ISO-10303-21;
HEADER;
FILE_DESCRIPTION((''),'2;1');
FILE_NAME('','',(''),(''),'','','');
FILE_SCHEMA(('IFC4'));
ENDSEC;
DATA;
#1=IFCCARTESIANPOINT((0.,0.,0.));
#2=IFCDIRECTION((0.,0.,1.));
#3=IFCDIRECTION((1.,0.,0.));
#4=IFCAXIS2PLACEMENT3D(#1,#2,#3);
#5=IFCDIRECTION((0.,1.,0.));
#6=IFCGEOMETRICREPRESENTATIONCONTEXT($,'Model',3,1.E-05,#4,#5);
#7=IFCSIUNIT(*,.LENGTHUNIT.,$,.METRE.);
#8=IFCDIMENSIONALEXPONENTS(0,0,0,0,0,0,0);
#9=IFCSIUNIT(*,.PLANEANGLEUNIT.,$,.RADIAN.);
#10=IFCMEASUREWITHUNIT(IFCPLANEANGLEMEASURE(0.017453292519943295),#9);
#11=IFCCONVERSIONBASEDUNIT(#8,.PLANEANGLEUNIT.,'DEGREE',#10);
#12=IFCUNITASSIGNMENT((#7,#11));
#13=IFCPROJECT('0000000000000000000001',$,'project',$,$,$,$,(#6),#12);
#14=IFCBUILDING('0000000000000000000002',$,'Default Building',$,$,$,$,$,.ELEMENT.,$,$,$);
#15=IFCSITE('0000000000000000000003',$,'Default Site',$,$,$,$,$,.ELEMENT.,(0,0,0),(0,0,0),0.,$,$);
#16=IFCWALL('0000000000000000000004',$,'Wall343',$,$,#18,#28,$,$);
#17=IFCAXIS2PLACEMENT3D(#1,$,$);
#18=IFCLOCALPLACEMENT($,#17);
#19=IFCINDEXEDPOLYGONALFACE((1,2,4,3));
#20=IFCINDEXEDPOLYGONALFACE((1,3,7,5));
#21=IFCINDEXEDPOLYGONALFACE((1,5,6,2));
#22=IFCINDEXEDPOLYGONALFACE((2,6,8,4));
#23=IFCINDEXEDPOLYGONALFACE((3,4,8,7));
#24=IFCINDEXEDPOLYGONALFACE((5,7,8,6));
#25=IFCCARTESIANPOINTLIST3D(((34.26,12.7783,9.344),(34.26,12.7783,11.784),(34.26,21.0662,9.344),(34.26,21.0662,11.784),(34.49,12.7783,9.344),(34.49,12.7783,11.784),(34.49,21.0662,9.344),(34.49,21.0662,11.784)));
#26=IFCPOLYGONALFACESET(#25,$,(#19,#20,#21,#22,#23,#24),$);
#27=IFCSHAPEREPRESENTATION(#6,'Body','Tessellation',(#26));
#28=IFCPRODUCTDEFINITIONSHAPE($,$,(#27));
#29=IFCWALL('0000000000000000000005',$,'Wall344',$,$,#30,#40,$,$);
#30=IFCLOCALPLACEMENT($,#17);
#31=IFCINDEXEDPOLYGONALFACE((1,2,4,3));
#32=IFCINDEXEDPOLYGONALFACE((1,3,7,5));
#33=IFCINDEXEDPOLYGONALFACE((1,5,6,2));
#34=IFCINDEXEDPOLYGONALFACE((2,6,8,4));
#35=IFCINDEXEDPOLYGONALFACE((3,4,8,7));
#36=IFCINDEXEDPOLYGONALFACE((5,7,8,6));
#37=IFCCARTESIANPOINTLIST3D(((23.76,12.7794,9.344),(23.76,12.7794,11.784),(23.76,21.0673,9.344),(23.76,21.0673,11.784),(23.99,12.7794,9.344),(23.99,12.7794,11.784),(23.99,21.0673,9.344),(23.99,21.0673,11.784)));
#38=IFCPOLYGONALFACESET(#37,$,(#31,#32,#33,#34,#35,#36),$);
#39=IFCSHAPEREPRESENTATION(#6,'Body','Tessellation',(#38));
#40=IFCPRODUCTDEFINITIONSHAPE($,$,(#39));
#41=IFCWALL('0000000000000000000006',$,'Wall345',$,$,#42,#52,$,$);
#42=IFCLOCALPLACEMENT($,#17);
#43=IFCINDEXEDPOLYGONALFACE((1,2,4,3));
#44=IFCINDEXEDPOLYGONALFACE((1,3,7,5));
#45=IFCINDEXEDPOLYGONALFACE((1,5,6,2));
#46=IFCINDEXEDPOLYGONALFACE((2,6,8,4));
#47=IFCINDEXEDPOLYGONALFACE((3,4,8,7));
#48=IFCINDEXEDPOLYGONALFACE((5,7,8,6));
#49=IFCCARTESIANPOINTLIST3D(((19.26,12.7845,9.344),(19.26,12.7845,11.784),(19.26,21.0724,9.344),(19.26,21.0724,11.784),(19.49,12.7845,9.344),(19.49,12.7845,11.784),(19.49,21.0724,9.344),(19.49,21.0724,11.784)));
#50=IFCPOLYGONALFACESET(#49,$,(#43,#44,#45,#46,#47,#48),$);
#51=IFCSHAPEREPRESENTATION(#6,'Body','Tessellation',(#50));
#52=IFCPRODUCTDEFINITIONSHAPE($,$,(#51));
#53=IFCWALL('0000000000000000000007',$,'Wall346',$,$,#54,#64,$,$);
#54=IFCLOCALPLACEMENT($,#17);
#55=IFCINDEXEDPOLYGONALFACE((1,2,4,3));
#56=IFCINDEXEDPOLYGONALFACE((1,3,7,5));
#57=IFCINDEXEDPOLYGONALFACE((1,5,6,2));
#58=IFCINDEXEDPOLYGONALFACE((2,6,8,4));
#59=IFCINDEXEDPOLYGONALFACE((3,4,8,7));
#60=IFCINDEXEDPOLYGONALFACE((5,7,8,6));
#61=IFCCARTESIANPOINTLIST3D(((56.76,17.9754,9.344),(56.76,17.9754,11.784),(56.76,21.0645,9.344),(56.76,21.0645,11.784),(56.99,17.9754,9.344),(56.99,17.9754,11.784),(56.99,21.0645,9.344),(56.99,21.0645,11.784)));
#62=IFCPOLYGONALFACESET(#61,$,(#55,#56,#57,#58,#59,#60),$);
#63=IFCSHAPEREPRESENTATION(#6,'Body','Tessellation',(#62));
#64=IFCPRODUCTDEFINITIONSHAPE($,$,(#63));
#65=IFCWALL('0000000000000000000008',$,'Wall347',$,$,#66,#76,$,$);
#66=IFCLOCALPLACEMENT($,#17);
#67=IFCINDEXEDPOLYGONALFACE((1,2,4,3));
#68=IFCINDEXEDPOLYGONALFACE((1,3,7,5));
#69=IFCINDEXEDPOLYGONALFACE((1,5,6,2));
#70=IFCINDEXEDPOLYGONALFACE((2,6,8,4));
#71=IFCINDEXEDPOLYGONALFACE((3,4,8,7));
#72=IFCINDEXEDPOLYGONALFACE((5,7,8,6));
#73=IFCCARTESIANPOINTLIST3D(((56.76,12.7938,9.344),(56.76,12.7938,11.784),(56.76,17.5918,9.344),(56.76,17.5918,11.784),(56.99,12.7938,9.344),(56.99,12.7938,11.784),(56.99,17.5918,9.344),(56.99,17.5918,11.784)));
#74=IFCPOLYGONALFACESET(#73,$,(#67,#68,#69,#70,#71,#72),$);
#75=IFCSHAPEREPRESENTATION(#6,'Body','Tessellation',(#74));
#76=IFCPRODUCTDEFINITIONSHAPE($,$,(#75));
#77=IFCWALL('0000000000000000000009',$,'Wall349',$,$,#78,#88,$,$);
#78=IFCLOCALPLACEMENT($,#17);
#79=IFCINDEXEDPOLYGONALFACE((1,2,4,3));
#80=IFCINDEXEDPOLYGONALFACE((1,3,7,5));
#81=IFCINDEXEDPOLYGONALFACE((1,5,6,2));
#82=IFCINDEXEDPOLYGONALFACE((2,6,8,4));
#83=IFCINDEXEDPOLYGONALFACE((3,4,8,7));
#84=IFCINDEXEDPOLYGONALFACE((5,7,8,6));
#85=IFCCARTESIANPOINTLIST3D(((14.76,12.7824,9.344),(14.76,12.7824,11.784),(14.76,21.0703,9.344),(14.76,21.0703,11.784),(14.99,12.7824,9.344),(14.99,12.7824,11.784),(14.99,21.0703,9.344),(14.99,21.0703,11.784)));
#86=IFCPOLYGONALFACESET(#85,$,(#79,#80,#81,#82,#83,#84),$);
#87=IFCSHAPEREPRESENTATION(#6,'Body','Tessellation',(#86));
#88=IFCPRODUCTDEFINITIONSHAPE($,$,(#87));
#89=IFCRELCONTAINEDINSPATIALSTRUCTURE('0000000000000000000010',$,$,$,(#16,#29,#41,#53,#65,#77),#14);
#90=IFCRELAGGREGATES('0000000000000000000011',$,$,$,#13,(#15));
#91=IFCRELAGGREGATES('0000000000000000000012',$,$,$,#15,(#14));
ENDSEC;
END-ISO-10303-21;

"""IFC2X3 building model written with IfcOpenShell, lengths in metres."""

from ifc_helpers import new_model, entity, si_unit, converted_unit, direction, frame, frame_2d, origin_with_axes, place, context, project, spatial, rectangle, extrude, element, save


model = new_model("IFC2X3")

# Units and contexts
model_context = context("Model", 3, precision=1e-05, world=origin_with_axes(), true_north=direction((0.0, 1.0, 0.0)))
ifc_project = project(units=[si_unit("LENGTHUNIT", "METRE"), converted_unit("PLANEANGLEUNIT", "DEGREE", entity("IfcPlaneAngleMeasure", 0.017453292519943295), si_unit("PLANEANGLEUNIT", "RADIAN"), dimensions=[0, 0, 0, 0, 0, 0, 0])], contexts=[model_context])

# Site, building
site = spatial("IfcSite", under=ifc_project, Name="Default Site", CompositionType="ELEMENT", RefLatitude=(0, 0, 0), RefLongitude=(0, 0, 0), RefElevation=0.0)
building = spatial("IfcBuilding", under=site, Name="Default Building", CompositionType="ELEMENT")

# Shared definitions
placement = place(None, origin_with_axes())

# Walls
element("IfcWall", 1, at=placement, inside=building, Name="Wall343", context=model_context, shape_type="SweptSolid", body=[
    extrude(rectangle(XDim=8.2879, YDim=0.23, at=frame_2d((0.0, 0.0), x_axis=(0.0, 1.0, 0.0))), frame((34.375, 16.9223, 9.344), z_axis=(0.0, 0.0, 1.0), x_axis=(1.0, 0.0, 0.0)), (0.0, 0.0, 1.0), 2.44),
])
element("IfcWall", 2, at=placement, inside=building, Name="Wall344", context=model_context, shape_type="SweptSolid", body=[
    extrude(rectangle(XDim=8.2879, YDim=0.23, at=frame_2d((0.0, 0.0), x_axis=(0.0, 1.0, 0.0))), frame((23.875, 16.9233, 9.344), z_axis=(0.0, 0.0, 1.0), x_axis=(1.0, 0.0, 0.0)), (0.0, 0.0, 1.0), 2.44),
])
element("IfcWall", 3, at=placement, inside=building, Name="Wall345", context=model_context, shape_type="SweptSolid", body=[
    extrude(rectangle(XDim=8.2879, YDim=0.23, at=frame_2d((0.0, 0.0), x_axis=(0.0, 1.0, 0.0))), frame((19.375, 16.9284, 9.344), z_axis=(0.0, 0.0, 1.0), x_axis=(1.0, 0.0, 0.0)), (0.0, 0.0, 1.0), 2.44),
])
element("IfcWall", 4, at=placement, inside=building, Name="Wall346", context=model_context, shape_type="SweptSolid", body=[
    extrude(rectangle(XDim=3.0891, YDim=0.23, at=frame_2d((0.0, 0.0), x_axis=(0.0, -1.0, 0.0))), frame((56.875, 19.52, 9.344), z_axis=(0.0, 0.0, 1.0), x_axis=(1.0, 0.0, 0.0)), (0.0, 0.0, 1.0), 2.44),
])
element("IfcWall", 5, at=placement, inside=building, Name="Wall347", context=model_context, shape_type="SweptSolid", body=[
    extrude(rectangle(XDim=4.798, YDim=0.23, at=frame_2d((0.0, 0.0), x_axis=(0.0, -1.0, 0.0))), frame((56.875, 15.1928, 9.344), z_axis=(0.0, 0.0, 1.0), x_axis=(1.0, 0.0, 0.0)), (0.0, 0.0, 1.0), 2.44),
])
element("IfcWall", 6, at=placement, inside=building, Name="Wall349", context=model_context, shape_type="SweptSolid", body=[
    extrude(rectangle(XDim=8.2879, YDim=0.23, at=frame_2d((0.0, 0.0), x_axis=(0.0, 1.0, 0.0))), frame((14.875, 16.9263, 9.344), z_axis=(0.0, 0.0, 1.0), x_axis=(1.0, 0.0, 0.0)), (0.0, 0.0, 1.0), 2.44),
])

save(model, "model.ifc")
